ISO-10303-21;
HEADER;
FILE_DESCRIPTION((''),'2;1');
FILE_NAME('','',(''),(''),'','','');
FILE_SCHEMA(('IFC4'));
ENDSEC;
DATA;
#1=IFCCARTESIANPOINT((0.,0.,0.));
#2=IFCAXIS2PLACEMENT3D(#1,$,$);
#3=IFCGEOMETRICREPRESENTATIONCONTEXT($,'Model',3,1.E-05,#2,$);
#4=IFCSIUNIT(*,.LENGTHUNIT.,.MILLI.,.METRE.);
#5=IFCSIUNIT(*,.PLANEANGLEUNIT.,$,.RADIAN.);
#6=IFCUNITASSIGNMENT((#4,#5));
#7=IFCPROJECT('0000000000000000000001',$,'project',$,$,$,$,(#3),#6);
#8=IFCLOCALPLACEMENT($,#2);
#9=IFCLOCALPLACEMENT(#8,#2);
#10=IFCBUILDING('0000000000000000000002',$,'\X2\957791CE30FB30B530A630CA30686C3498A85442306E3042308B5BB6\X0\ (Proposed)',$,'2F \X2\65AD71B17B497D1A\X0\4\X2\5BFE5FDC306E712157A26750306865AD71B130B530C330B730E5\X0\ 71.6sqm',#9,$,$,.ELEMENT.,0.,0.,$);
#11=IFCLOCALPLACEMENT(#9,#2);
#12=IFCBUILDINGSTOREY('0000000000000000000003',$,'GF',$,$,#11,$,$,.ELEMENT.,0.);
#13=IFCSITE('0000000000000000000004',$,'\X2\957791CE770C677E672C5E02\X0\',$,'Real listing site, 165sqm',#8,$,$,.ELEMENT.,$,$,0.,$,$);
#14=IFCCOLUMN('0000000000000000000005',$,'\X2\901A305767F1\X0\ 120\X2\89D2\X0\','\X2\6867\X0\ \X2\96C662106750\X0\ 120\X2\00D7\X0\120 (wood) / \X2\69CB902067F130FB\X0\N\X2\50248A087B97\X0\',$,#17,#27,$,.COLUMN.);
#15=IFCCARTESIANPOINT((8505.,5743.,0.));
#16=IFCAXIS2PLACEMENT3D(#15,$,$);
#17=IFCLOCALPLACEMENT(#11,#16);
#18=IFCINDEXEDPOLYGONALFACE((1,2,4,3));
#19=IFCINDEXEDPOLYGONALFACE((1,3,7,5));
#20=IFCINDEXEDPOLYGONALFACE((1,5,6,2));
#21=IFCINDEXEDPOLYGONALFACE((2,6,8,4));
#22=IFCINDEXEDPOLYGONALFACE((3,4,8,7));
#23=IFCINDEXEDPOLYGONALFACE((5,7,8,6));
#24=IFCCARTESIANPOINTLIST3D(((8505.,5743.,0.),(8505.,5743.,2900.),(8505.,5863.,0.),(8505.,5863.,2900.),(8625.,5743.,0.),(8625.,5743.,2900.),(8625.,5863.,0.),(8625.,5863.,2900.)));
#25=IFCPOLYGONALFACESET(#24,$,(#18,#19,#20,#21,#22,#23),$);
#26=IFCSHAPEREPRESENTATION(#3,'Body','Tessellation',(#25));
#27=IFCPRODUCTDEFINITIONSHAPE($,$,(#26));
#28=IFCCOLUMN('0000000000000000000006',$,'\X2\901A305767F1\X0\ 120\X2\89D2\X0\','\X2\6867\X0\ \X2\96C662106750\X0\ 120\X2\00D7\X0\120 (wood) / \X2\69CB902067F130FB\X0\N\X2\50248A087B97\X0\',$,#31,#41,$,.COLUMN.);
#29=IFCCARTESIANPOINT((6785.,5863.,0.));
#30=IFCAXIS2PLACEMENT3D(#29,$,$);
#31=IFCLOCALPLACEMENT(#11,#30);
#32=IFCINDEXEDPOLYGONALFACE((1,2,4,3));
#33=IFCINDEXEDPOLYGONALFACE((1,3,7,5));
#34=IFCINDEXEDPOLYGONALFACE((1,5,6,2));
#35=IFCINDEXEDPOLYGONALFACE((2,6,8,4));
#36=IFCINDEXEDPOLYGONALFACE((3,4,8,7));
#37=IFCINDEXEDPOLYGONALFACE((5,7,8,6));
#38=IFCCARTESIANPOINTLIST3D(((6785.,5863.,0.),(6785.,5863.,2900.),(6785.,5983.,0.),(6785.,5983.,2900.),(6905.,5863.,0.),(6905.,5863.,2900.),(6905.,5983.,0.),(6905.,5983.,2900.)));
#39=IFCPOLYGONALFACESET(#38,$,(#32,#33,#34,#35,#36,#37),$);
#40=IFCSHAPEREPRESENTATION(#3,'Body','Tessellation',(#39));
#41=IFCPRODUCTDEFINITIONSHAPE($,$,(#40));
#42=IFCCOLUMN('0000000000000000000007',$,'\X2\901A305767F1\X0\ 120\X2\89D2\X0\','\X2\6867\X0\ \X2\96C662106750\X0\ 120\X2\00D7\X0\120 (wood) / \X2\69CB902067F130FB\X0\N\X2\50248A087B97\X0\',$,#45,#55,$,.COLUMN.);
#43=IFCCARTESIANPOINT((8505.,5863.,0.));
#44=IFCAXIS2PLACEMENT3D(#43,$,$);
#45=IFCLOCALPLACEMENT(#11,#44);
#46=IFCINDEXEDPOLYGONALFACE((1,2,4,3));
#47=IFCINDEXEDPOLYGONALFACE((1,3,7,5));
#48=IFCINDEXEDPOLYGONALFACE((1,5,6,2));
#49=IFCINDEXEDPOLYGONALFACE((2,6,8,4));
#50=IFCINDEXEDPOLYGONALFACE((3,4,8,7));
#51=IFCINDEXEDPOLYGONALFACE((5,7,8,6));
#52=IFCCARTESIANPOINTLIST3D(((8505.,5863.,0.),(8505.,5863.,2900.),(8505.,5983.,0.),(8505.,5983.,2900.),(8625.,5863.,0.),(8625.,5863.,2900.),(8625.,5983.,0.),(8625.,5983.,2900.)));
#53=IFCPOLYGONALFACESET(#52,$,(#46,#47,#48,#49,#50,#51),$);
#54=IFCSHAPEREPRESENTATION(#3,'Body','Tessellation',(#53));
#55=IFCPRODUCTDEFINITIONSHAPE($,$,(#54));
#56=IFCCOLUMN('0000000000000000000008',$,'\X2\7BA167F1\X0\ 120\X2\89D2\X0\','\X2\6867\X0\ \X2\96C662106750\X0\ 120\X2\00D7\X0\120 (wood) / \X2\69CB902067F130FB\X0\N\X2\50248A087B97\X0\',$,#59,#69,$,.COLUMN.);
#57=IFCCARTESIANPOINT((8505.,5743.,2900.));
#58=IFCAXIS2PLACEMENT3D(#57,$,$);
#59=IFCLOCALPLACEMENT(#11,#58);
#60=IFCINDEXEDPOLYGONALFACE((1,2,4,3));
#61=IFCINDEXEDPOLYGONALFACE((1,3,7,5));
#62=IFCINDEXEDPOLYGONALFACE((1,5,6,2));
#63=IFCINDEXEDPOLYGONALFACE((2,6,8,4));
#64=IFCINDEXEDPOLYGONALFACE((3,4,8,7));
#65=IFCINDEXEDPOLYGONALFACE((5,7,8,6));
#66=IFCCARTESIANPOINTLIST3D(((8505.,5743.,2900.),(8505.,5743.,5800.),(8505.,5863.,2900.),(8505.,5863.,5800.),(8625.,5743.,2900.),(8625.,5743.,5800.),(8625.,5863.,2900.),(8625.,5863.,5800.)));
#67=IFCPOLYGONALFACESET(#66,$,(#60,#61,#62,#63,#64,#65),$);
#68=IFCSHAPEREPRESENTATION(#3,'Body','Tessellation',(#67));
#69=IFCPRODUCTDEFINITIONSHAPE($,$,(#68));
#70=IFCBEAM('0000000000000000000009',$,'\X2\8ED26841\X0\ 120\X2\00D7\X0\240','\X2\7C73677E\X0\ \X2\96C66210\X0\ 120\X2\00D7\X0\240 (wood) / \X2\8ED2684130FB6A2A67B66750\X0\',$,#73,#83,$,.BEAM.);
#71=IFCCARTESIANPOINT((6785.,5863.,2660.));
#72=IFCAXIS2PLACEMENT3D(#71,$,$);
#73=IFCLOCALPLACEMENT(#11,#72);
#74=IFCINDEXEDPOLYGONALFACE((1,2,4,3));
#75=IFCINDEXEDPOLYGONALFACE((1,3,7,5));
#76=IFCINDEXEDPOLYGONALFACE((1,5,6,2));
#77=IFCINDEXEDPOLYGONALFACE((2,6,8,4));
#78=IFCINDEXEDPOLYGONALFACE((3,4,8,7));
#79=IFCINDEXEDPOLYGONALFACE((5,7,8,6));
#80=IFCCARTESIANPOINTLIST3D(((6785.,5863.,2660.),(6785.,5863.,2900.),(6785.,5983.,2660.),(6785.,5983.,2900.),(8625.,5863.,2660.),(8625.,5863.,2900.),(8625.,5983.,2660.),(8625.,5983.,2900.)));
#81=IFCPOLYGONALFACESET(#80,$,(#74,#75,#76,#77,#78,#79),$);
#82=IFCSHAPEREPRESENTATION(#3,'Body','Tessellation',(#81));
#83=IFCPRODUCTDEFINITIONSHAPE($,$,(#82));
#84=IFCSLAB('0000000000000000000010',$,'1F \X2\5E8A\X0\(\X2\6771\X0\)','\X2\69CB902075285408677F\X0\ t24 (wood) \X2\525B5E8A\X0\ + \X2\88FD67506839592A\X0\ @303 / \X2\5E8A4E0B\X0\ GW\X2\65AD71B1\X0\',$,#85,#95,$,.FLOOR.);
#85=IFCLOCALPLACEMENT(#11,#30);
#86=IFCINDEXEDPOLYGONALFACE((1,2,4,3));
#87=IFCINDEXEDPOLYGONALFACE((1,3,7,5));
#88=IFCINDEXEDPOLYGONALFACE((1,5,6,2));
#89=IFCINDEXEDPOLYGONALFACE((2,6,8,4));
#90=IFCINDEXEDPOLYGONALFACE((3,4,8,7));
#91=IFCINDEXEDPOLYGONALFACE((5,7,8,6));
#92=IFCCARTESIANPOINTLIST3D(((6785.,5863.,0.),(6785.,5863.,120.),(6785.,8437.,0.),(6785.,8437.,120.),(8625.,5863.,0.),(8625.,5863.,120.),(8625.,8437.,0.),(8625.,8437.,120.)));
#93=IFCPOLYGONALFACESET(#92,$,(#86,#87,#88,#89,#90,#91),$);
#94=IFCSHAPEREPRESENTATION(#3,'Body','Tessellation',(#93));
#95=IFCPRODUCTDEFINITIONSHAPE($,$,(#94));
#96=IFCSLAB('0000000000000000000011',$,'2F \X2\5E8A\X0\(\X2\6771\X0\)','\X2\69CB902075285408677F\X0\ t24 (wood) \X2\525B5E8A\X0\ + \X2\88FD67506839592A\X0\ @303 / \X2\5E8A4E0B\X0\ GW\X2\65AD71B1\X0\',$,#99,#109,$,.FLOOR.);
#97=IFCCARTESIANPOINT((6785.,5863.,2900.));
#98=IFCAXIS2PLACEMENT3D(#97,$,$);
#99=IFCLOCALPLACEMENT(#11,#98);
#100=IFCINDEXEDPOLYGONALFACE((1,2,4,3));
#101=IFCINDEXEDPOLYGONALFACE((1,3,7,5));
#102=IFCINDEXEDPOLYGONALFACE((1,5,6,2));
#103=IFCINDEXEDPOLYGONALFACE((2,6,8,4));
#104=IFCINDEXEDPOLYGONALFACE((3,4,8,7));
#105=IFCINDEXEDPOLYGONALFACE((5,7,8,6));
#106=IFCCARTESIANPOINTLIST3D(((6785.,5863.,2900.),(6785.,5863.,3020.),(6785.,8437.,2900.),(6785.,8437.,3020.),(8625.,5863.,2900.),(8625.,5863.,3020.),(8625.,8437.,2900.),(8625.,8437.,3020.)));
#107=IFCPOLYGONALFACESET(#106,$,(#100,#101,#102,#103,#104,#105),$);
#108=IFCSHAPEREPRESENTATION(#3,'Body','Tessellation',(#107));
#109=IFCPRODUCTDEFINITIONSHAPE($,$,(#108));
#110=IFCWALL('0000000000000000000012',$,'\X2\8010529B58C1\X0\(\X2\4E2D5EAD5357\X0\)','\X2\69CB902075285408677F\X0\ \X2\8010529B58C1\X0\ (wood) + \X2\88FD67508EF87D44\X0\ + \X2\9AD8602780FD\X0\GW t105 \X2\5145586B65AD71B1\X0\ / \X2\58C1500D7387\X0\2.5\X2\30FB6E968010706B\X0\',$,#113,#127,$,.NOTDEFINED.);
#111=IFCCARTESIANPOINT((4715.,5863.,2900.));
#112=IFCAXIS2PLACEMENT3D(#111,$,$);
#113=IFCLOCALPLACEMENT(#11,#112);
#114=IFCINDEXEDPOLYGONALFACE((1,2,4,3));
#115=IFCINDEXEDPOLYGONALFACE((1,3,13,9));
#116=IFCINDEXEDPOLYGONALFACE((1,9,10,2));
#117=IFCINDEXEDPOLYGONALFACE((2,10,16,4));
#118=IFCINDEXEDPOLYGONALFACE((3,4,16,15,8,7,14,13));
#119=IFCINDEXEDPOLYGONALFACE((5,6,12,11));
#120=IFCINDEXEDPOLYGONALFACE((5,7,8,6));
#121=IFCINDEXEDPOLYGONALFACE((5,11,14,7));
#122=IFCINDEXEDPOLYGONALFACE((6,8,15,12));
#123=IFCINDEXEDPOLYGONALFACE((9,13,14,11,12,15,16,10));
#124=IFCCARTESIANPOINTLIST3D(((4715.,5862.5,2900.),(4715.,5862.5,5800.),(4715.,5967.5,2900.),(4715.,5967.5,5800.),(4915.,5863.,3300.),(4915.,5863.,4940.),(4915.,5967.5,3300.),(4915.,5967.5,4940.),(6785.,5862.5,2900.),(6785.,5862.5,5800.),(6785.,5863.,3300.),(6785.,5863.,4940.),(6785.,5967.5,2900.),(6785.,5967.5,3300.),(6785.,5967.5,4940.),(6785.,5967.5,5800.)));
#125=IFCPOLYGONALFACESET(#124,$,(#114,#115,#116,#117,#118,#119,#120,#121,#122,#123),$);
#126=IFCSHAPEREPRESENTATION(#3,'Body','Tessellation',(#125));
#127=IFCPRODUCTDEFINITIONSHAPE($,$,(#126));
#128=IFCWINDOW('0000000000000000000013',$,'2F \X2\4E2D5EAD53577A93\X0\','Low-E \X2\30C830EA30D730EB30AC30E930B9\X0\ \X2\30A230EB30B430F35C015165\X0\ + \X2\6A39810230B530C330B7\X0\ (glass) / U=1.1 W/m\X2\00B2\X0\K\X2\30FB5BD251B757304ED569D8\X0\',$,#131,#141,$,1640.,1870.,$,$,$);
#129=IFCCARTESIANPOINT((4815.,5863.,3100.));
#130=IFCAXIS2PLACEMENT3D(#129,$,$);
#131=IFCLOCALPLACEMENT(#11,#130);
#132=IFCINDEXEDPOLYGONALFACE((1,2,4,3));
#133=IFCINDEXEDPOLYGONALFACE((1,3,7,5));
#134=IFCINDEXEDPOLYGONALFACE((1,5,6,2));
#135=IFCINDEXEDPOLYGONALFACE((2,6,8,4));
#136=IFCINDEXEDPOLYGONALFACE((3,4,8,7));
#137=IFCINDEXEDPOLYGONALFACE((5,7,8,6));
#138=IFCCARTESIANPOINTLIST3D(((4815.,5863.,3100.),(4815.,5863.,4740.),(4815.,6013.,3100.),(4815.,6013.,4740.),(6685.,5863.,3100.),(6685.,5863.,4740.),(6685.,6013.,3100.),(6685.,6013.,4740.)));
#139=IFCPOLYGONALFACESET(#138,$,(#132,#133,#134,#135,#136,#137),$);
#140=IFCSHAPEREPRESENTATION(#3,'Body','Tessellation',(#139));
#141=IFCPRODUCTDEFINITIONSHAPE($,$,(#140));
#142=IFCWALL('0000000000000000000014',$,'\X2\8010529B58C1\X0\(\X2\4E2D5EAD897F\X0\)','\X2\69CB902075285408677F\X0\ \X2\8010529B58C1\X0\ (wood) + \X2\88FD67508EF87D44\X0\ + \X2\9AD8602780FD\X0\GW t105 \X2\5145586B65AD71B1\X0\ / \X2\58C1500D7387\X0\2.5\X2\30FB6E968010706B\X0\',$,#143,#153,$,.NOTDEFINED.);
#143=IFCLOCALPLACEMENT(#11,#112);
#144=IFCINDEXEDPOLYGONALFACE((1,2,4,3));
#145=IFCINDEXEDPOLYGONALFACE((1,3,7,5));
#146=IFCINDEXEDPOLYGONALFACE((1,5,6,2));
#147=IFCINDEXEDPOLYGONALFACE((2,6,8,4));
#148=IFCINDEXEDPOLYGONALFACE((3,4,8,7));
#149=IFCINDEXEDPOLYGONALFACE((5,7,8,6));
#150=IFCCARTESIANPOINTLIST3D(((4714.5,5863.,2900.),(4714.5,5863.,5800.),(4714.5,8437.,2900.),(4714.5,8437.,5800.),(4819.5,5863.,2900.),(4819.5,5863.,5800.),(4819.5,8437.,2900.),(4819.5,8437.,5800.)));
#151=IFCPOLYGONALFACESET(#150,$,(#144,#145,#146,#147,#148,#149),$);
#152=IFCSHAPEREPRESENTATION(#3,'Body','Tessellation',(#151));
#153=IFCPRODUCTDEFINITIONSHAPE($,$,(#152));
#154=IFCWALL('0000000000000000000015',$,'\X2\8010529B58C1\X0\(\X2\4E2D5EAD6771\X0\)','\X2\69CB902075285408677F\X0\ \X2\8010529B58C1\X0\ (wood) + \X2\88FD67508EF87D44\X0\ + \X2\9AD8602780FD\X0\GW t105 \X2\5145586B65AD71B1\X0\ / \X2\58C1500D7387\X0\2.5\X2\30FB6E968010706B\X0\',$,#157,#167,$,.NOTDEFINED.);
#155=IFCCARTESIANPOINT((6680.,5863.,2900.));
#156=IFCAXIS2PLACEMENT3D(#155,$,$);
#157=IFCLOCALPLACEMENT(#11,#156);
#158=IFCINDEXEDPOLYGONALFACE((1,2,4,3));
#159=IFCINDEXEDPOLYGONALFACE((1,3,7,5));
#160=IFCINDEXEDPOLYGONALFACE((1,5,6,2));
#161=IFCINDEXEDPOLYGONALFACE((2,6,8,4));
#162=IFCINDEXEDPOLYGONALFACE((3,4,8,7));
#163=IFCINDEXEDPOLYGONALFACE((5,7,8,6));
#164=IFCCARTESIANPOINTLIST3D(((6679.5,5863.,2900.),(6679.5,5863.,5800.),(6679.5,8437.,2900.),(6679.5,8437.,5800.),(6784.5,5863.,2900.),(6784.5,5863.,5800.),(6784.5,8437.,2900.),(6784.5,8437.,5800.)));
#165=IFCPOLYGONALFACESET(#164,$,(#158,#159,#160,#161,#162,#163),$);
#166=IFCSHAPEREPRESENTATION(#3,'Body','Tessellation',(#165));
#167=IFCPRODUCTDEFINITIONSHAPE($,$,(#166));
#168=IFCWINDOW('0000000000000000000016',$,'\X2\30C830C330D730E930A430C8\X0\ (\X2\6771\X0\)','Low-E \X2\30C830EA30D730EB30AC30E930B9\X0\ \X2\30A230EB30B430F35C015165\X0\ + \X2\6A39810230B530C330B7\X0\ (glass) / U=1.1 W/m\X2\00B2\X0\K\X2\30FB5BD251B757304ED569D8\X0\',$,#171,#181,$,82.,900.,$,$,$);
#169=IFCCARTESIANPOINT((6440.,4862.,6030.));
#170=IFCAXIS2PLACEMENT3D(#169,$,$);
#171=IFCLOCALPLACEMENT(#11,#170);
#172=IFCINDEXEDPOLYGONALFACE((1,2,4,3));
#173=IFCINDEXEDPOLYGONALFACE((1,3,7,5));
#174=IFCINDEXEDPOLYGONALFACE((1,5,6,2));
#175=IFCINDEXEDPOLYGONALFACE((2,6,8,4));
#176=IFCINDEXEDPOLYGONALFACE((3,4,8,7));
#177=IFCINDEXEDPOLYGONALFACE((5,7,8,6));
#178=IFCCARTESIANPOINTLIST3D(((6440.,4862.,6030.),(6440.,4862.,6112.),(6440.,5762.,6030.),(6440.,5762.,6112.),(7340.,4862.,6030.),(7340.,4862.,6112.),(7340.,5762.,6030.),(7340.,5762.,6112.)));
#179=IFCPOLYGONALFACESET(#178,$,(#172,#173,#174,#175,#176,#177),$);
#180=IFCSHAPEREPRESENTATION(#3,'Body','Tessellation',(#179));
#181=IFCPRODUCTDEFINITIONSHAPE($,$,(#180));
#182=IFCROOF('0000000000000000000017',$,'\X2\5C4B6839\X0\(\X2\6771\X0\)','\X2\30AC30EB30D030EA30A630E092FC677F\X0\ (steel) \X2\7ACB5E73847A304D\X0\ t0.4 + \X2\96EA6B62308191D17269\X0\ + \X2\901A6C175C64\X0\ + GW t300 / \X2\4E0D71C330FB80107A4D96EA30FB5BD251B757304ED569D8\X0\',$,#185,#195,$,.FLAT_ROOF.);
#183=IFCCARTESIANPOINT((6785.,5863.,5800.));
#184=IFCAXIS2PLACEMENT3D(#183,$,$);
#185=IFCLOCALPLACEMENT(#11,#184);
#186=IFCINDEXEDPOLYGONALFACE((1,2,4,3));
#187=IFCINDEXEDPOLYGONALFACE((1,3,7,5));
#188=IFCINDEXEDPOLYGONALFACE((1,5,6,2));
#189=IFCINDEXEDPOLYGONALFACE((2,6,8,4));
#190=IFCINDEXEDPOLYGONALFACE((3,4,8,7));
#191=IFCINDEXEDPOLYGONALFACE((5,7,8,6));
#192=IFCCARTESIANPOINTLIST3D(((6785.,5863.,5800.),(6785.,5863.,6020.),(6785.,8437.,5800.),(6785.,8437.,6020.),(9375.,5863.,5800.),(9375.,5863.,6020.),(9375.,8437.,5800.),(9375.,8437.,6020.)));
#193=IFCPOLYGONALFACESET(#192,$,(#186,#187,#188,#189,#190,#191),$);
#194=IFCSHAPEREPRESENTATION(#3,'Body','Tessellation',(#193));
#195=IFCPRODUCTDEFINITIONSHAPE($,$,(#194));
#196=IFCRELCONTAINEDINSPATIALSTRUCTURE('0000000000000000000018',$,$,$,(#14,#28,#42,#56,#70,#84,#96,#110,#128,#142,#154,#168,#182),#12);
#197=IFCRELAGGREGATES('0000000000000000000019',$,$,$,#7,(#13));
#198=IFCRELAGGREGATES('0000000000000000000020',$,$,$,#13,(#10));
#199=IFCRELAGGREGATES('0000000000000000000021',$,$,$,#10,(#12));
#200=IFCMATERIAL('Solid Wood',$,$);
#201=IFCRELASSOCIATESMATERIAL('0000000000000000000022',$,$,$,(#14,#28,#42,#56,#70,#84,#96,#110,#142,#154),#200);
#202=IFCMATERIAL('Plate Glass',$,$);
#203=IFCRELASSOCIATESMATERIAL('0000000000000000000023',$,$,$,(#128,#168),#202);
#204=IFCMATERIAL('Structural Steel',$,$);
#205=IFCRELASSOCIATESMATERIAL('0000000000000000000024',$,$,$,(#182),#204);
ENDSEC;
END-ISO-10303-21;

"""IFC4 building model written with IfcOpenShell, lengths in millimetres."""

from ifc_helpers import new_model, si_unit, frame, frame_2d, origin, place, context, project, spatial, rectangle, extrude, material, element, fill, save


model = new_model("IFC4")

# Units and contexts
model_context = context("Model", 3, precision=1e-05, world=origin())
ifc_project = project(units=[si_unit("LENGTHUNIT", "METRE", prefix="MILLI"), si_unit("PLANEANGLEUNIT", "RADIAN")], contexts=[model_context])

# Site, building, storey
site_placement = place(None, origin())
site = spatial("IfcSite", under=ifc_project, at=site_placement, Name="長野県松本市", ObjectType="Real listing site, 165sqm", CompositionType="ELEMENT", RefElevation=0.0)
building_placement = place(site_placement, origin())
building = spatial("IfcBuilding", under=site, at=building_placement, Name="長野・サウナと水風呂のある家 (Proposed)", ObjectType="2F 断熱等級4対応の無垢材と断熱サッシュ 71.6sqm", CompositionType="ELEMENT", ElevationOfRefHeight=0.0, ElevationOfTerrain=0.0)
storey_placement = place(building_placement, origin())
storey = spatial("IfcBuildingStorey", under=building, at=storey_placement, Name="GF", CompositionType="ELEMENT", Elevation=0.0)

# Columns
ifc_material_1 = material(Name="Solid Wood")
column_1_placement = place(storey_placement, frame((8505.0, 5743.0, 0.0)))
element("IfcColumn", 1, at=column_1_placement, inside=storey, material=ifc_material_1, Name="通し柱 120角", Description="桧 集成材 120×120 (wood) / 構造柱・N値計算", PredefinedType="COLUMN", context=model_context, shape_type="SweptSolid", body=[
    extrude(rectangle(XDim=120.0, YDim=120.0, at=frame_2d((60.0, 60.0))), frame((8505.0, 5743.0, 0.0)), (0.0, 0.0, 1.0), 2900.0),
])
column_2_placement = place(storey_placement, frame((6785.0, 5863.0, 0.0)))
element("IfcColumn", 2, at=column_2_placement, inside=storey, material=ifc_material_1, Name="通し柱 120角", Description="桧 集成材 120×120 (wood) / 構造柱・N値計算", PredefinedType="COLUMN", context=model_context, shape_type="SweptSolid", body=[
    extrude(rectangle(XDim=120.0, YDim=120.0, at=frame_2d((60.0, 60.0))), frame((6785.0, 5863.0, 0.0)), (0.0, 0.0, 1.0), 2900.0),
])
column_3_placement = place(storey_placement, frame((8505.0, 5863.0, 0.0)))
element("IfcColumn", 3, at=column_3_placement, inside=storey, material=ifc_material_1, Name="通し柱 120角", Description="桧 集成材 120×120 (wood) / 構造柱・N値計算", PredefinedType="COLUMN", context=model_context, shape_type="SweptSolid", body=[
    extrude(rectangle(XDim=120.0, YDim=120.0, at=frame_2d((60.0, 60.0))), frame((8505.0, 5863.0, 0.0)), (0.0, 0.0, 1.0), 2900.0),
])
column_4_placement = place(storey_placement, frame((8505.0, 5743.0, 2900.0)))
element("IfcColumn", 4, at=column_4_placement, inside=storey, material=ifc_material_1, Name="管柱 120角", Description="桧 集成材 120×120 (wood) / 構造柱・N値計算", PredefinedType="COLUMN", context=model_context, shape_type="SweptSolid", body=[
    extrude(rectangle(XDim=120.0, YDim=120.0, at=frame_2d((60.0, 60.0))), frame((8505.0, 5743.0, 2900.0)), (0.0, 0.0, 1.0), 2900.0),
])

# Beam
beam_1_placement = place(storey_placement, frame((6785.0, 5863.0, 2660.0)))
element("IfcBeam", 5, at=beam_1_placement, inside=storey, material=ifc_material_1, Name="軒桁 120×240", Description="米松 集成 120×240 (wood) / 軒桁・横架材", PredefinedType="BEAM", context=model_context, shape_type="SweptSolid", body=[
    extrude(rectangle(XDim=1840.0, YDim=120.0, at=frame_2d((920.0, 60.0))), frame((6785.0, 5863.0, 2660.0)), (0.0, 0.0, 1.0), 240.0),
])

# Slabs
slab_1_placement = place(storey_placement, frame((6785.0, 5863.0, 0.0)))
element("IfcSlab", 6, at=slab_1_placement, inside=storey, material=ifc_material_1, Name="1F 床(東)", Description="構造用合板 t24 (wood) 剛床 + 製材根太 @303 / 床下 GW断熱", PredefinedType="FLOOR", context=model_context, shape_type="SweptSolid", body=[
    extrude(rectangle(XDim=1840.0, YDim=2574.0, at=frame_2d((920.0, 1287.0))), frame((6785.0, 5863.0, 0.0)), (0.0, 0.0, 1.0), 120.0),
])
slab_2_placement = place(storey_placement, frame((6785.0, 5863.0, 2900.0)))
element("IfcSlab", 7, at=slab_2_placement, inside=storey, material=ifc_material_1, Name="2F 床(東)", Description="構造用合板 t24 (wood) 剛床 + 製材根太 @303 / 床下 GW断熱", PredefinedType="FLOOR", context=model_context, shape_type="SweptSolid", body=[
    extrude(rectangle(XDim=1840.0, YDim=2574.0, at=frame_2d((920.0, 1287.0))), frame((6785.0, 5863.0, 2900.0)), (0.0, 0.0, 1.0), 120.0),
])

# Wall, opening, window
wall_1_placement = place(storey_placement, frame((4715.0, 5863.0, 2900.0)))
wall_1 = element("IfcWall", 8, at=wall_1_placement, inside=storey, material=ifc_material_1, Name="耐力壁(中庭南)", Description="構造用合板 耐力壁 (wood) + 製材軸組 + 高性能GW t105 充填断熱 / 壁倍率2.5・準耐火", PredefinedType="NOTDEFINED", context=model_context, shape_type="SweptSolid", body=[
    extrude(rectangle(XDim=2070.0, YDim=105.0, at=frame_2d((1035.0, 52.0))), frame((4715.0, 5863.0, 2900.0)), (0.0, 0.0, 1.0), 2900.0),
])
opening_placement = place(storey_placement, frame((4815.0, 5863.0, 3100.0)))
opening = element("IfcOpeningElement", 9, at=opening_placement, cuts=wall_1, PredefinedType="NOTDEFINED", context=model_context, shape_type="SweptSolid", body=[
    extrude(rectangle(XDim=1870.0, YDim=150.0, at=frame_2d((935.0, 75.0))), frame((4815.0, 5863.0, 3100.0)), (0.0, 0.0, 1.0), 1640.0),
])
ifc_material_2 = material(Name="Plate Glass")
window_1_placement = place(storey_placement, frame((4815.0, 5863.0, 3100.0)))
window_1 = element("IfcWindow", 10, at=window_1_placement, inside=storey, material=ifc_material_2, Name="2F 中庭南窓", Description="Low-E トリプルガラス アルゴン封入 + 樹脂サッシ (glass) / U=1.1 W/m²K・寒冷地仕様", OverallHeight=1640.0, OverallWidth=1870.0, context=model_context, shape_type="SweptSolid", body=[
    extrude(rectangle(XDim=1870.0, YDim=150.0, at=frame_2d((935.0, 75.0))), frame((4815.0, 5863.0, 3100.0)), (0.0, 0.0, 1.0), 1640.0),
])
fill(opening, window_1)

# Walls
wall_2_placement = place(storey_placement, frame((4715.0, 5863.0, 2900.0)))
element("IfcWall", 11, at=wall_2_placement, inside=storey, material=ifc_material_1, Name="耐力壁(中庭西)", Description="構造用合板 耐力壁 (wood) + 製材軸組 + 高性能GW t105 充填断熱 / 壁倍率2.5・準耐火", PredefinedType="NOTDEFINED", context=model_context, shape_type="SweptSolid", body=[
    extrude(rectangle(XDim=105.0, YDim=2574.0, at=frame_2d((52.0, 1287.0))), frame((4715.0, 5863.0, 2900.0)), (0.0, 0.0, 1.0), 2900.0),
])
wall_3_placement = place(storey_placement, frame((6680.0, 5863.0, 2900.0)))
element("IfcWall", 12, at=wall_3_placement, inside=storey, material=ifc_material_1, Name="耐力壁(中庭東)", Description="構造用合板 耐力壁 (wood) + 製材軸組 + 高性能GW t105 充填断熱 / 壁倍率2.5・準耐火", PredefinedType="NOTDEFINED", context=model_context, shape_type="SweptSolid", body=[
    extrude(rectangle(XDim=105.0, YDim=2574.0, at=frame_2d((52.0, 1287.0))), frame((6680.0, 5863.0, 2900.0)), (0.0, 0.0, 1.0), 2900.0),
])

# Window
window_2_placement = place(storey_placement, frame((6440.0, 4862.0, 6030.0)))
element("IfcWindow", 13, at=window_2_placement, inside=storey, material=ifc_material_2, Name="トップライト (東)", Description="Low-E トリプルガラス アルゴン封入 + 樹脂サッシ (glass) / U=1.1 W/m²K・寒冷地仕様", OverallHeight=82.0, OverallWidth=900.0, context=model_context, shape_type="SweptSolid", body=[
    extrude(rectangle(XDim=900.0, YDim=900.0, at=frame_2d((450.0, 450.0))), frame((6440.0, 4862.0, 6030.0)), (0.0, 0.0, 1.0), 82.0),
])

# Roof
ifc_material_3 = material(Name="Structural Steel")
for number, where, name in (
    (14, (6785.0, 5863.0, 5800.0), "屋根(東)"),
):
    element("IfcRoof", number, at=place(storey_placement, frame(where)), inside=storey, material=ifc_material_3, Name=name, Description="ガルバリウム鋼板 (steel) 立平葺き t0.4 + 雪止め金物 + 通気層 + GW t300 / 不燃・耐積雪・寒冷地仕様", PredefinedType="FLAT_ROOF", context=model_context, shape_type="SweptSolid", body=[
        extrude(rectangle(XDim=2590.0, YDim=2574.0, at=frame_2d((1295.0, 1287.0))), frame((6785.0, 5863.0, 5800.0)), (0.0, 0.0, 1.0), 220.0),
    ])

save(model, "model.ifc")
